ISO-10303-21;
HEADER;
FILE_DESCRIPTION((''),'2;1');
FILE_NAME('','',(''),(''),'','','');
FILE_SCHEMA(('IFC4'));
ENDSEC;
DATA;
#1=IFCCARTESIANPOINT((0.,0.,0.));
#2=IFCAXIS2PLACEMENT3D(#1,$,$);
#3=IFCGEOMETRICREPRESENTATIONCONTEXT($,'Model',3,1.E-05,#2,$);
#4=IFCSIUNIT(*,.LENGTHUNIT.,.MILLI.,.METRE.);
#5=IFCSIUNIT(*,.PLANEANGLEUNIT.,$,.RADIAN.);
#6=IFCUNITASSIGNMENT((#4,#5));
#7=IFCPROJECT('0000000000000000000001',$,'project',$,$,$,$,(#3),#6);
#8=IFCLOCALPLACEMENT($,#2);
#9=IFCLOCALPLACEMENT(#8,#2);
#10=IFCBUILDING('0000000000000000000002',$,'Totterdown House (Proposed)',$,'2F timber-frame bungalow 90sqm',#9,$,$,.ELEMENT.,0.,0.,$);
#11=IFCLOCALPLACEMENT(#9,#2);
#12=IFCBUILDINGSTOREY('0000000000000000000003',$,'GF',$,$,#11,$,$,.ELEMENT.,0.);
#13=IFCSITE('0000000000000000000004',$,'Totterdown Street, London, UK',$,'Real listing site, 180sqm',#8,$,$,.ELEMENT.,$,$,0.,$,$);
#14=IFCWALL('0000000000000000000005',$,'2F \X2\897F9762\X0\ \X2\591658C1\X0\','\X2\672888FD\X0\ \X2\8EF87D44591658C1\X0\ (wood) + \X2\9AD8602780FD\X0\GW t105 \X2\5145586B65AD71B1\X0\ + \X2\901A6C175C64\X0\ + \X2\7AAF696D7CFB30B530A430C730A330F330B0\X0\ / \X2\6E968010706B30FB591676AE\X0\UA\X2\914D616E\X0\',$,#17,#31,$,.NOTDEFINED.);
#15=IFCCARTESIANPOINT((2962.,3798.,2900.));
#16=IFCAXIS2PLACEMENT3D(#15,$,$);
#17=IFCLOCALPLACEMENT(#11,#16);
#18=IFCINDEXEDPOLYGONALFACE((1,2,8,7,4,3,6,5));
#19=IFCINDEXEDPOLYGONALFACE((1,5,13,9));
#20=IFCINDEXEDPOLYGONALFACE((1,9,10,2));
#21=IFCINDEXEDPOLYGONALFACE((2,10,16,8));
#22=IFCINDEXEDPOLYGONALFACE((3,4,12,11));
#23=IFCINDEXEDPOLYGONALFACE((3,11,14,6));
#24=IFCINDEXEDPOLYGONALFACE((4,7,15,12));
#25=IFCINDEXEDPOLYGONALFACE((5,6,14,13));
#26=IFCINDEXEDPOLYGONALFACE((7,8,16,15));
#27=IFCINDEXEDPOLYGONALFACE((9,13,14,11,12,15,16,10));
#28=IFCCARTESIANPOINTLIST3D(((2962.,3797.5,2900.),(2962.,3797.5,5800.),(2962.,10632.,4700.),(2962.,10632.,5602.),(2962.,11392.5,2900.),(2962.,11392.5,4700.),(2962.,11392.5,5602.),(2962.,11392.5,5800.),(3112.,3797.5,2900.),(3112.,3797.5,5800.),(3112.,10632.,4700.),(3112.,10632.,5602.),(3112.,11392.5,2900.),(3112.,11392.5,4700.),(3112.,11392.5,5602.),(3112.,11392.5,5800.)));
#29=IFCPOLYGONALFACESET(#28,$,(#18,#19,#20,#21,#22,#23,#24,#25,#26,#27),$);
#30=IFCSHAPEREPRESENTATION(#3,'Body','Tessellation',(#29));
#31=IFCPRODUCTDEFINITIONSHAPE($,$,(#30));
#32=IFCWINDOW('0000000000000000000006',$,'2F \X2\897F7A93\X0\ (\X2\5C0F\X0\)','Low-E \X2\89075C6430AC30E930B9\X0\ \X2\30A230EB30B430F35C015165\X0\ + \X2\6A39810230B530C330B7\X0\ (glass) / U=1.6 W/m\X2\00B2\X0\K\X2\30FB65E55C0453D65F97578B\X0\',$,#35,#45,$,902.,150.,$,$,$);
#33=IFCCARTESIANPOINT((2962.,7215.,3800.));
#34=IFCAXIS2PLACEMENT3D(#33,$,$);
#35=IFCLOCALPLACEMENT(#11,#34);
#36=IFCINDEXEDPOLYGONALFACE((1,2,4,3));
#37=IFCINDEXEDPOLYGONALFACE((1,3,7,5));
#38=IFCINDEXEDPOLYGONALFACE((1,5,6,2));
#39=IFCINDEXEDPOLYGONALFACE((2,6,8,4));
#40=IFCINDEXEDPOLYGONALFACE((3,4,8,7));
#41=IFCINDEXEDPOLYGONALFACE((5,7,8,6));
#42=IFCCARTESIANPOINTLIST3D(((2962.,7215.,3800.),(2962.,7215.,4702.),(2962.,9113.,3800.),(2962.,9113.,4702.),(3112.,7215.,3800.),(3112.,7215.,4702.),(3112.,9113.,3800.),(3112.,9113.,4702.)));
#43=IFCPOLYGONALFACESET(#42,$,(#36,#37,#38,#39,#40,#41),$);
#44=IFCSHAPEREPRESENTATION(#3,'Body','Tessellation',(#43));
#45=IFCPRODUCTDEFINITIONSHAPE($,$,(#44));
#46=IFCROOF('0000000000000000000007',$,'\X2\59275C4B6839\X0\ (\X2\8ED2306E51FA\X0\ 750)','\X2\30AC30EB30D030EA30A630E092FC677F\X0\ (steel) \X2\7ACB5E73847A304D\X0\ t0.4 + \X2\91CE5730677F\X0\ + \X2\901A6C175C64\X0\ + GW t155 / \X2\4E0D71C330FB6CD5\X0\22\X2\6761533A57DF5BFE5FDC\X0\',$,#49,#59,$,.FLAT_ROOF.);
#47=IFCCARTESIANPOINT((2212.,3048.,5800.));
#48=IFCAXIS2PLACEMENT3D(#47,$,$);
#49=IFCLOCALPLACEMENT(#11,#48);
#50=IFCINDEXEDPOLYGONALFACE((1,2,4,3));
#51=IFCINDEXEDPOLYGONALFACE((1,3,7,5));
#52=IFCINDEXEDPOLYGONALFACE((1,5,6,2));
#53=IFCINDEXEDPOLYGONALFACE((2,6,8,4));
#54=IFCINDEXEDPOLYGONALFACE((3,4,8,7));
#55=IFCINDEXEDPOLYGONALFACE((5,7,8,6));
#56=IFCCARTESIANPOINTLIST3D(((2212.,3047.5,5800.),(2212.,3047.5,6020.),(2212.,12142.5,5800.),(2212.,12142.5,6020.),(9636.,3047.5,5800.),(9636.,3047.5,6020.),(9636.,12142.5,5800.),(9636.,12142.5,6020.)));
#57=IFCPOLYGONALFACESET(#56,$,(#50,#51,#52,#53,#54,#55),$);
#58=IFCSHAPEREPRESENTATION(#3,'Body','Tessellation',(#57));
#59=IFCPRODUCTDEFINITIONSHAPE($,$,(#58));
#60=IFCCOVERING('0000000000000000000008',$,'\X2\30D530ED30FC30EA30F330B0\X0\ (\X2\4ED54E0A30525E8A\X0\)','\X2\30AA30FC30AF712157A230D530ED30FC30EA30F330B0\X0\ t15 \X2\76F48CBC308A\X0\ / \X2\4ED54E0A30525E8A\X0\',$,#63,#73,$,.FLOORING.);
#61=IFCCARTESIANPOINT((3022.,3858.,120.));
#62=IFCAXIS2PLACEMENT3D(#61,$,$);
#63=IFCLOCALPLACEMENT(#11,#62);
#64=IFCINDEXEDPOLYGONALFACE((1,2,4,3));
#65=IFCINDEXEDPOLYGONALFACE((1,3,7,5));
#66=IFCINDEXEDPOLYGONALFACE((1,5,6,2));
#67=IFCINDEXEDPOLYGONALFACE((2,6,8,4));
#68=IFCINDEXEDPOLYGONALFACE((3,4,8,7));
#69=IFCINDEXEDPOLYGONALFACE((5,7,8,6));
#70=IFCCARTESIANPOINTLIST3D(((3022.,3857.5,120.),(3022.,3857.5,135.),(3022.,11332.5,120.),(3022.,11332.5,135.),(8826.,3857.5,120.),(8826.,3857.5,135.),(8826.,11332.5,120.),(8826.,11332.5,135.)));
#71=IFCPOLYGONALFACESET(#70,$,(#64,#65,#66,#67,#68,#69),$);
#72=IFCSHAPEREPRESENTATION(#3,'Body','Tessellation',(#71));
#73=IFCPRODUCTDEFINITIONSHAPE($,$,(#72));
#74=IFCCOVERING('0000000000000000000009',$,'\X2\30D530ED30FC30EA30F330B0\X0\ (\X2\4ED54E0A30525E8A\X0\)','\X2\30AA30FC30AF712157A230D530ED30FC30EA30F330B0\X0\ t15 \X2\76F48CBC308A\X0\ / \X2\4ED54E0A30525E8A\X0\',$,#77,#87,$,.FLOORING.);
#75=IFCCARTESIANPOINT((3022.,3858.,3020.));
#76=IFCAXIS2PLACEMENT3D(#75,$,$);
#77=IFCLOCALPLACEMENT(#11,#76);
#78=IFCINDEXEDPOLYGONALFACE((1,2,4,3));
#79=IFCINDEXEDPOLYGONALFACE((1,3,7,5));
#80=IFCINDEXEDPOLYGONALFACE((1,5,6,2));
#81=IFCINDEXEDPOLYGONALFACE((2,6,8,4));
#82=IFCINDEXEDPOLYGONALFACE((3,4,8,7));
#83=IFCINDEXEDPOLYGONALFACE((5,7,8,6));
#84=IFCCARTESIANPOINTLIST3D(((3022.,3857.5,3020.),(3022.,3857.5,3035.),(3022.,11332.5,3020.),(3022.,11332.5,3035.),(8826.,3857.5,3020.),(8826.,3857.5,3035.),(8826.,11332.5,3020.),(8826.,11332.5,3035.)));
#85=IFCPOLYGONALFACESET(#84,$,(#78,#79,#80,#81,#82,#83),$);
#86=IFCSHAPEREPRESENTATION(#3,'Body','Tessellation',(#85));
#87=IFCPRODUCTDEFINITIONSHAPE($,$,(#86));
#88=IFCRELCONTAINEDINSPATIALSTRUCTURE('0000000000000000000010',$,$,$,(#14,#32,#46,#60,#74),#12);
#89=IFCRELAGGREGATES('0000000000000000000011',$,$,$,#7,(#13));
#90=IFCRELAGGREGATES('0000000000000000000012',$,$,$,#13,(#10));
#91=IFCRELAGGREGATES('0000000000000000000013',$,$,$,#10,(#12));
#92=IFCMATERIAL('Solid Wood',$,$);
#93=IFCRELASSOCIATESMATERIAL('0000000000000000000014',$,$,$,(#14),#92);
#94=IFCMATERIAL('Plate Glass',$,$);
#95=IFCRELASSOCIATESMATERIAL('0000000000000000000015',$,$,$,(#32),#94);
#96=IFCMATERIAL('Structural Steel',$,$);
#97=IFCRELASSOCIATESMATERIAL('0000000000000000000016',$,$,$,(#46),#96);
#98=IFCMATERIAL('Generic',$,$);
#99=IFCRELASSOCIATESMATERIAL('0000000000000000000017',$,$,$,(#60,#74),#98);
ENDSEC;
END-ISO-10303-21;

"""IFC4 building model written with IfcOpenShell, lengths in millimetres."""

from ifc_helpers import new_model, si_unit, frame, frame_2d, origin, place, context, project, spatial, rectangle, extrude, material, element, fill, save


model = new_model("IFC4")

# Units and contexts
model_context = context("Model", 3, precision=1e-05, world=origin())
ifc_project = project(units=[si_unit("LENGTHUNIT", "METRE", prefix="MILLI"), si_unit("PLANEANGLEUNIT", "RADIAN")], contexts=[model_context])

# Site, building, storey
site_placement = place(None, origin())
site = spatial("IfcSite", under=ifc_project, at=site_placement, Name="Totterdown Street, London, UK", ObjectType="Real listing site, 180sqm", CompositionType="ELEMENT", RefElevation=0.0)
building_placement = place(site_placement, origin())
building = spatial("IfcBuilding", under=site, at=building_placement, Name="Totterdown House (Proposed)", ObjectType="2F timber-frame bungalow 90sqm", CompositionType="ELEMENT", ElevationOfRefHeight=0.0, ElevationOfTerrain=0.0)
storey_placement = place(building_placement, origin())
storey = spatial("IfcBuildingStorey", under=building, at=storey_placement, Name="GF", CompositionType="ELEMENT", Elevation=0.0)

# Shared definitions
ifc_material_1 = material(Name="Solid Wood")

# Shared definitions
ifc_material_2 = material(Name="Plate Glass")

# Wall, opening, window
wall_1_placement = place(storey_placement, frame((2962.0, 3798.0, 2900.0)))
wall_1 = element("IfcWall", 1, at=wall_1_placement, inside=storey, material=ifc_material_1, Name="2F 西面 外壁", Description="木製 軸組外壁 (wood) + 高性能GW t105 充填断熱 + 通気層 + 窯業系サイディング / 準耐火・外皮UA配慮", PredefinedType="NOTDEFINED", context=model_context, shape_type="SweptSolid", body=[
    extrude(rectangle(XDim=150.0, YDim=7595.0, at=frame_2d((75.0, 3797.0))), frame((2962.0, 3798.0, 2900.0)), (0.0, 0.0, 1.0), 2900.0),
])
opening_1_placement = place(storey_placement, frame((2962.0, 7215.0, 3800.0)))
opening_1 = element("IfcOpeningElement", 2, at=opening_1_placement, cuts=wall_1, PredefinedType="NOTDEFINED", context=model_context, shape_type="SweptSolid", body=[
    extrude(rectangle(XDim=150.0, YDim=1898.0, at=frame_2d((75.0, 949.0))), frame((2962.0, 7215.0, 3800.0)), (0.0, 0.0, 1.0), 902.0),
])
window_1_placement = place(storey_placement, frame((2962.0, 7215.0, 3800.0)))
window_1 = element("IfcWindow", 3, at=window_1_placement, inside=storey, material=ifc_material_2, Name="2F 西窓 (小)", Description="Low-E 複層ガラス アルゴン封入 + 樹脂サッシ (glass) / U=1.6 W/m²K・日射取得型", OverallHeight=902.0, OverallWidth=150.0, context=model_context, shape_type="SweptSolid", body=[
    extrude(rectangle(XDim=150.0, YDim=1898.0, at=frame_2d((75.0, 949.0))), frame((2962.0, 7215.0, 3800.0)), (0.0, 0.0, 1.0), 902.0),
])
fill(opening_1, window_1)

# Roof
ifc_material_3 = material(Name="Structural Steel")
roof_placement = place(storey_placement, frame((2212.0, 3048.0, 5800.0)))
element("IfcRoof", 4, at=roof_placement, inside=storey, material=ifc_material_3, Name="大屋根 (軒の出 750)", Description="ガルバリウム鋼板 (steel) 立平葺き t0.4 + 野地板 + 通気層 + GW t155 / 不燃・法22条区域対応", PredefinedType="FLAT_ROOF", context=model_context, shape_type="SweptSolid", body=[
    extrude(rectangle(XDim=7424.0, YDim=9095.0, at=frame_2d((3712.0, 4547.0))), frame((2212.0, 3048.0, 5800.0)), (0.0, 0.0, 1.0), 220.0),
])

# Coverings
ifc_material_4 = material(Name="Generic")
covering_1_placement = place(storey_placement, frame((3022.0, 3858.0, 120.0)))
element("IfcCovering", 5, at=covering_1_placement, inside=storey, material=ifc_material_4, Name="フローリング (仕上げ床)", Description="オーク無垢フローリング t15 直貼り / 仕上げ床", PredefinedType="FLOORING", context=model_context, shape_type="SweptSolid", body=[
    extrude(rectangle(XDim=5804.0, YDim=7475.0, at=frame_2d((2902.0, 3737.0))), frame((3022.0, 3858.0, 120.0)), (0.0, 0.0, 1.0), 15.0),
])
covering_2_placement = place(storey_placement, frame((3022.0, 3858.0, 3020.0)))
element("IfcCovering", 6, at=covering_2_placement, inside=storey, material=ifc_material_4, Name="フローリング (仕上げ床)", Description="オーク無垢フローリング t15 直貼り / 仕上げ床", PredefinedType="FLOORING", context=model_context, shape_type="SweptSolid", body=[
    extrude(rectangle(XDim=5804.0, YDim=7475.0, at=frame_2d((2902.0, 3737.0))), frame((3022.0, 3858.0, 3020.0)), (0.0, 0.0, 1.0), 15.0),
])

save(model, "model.ifc")
